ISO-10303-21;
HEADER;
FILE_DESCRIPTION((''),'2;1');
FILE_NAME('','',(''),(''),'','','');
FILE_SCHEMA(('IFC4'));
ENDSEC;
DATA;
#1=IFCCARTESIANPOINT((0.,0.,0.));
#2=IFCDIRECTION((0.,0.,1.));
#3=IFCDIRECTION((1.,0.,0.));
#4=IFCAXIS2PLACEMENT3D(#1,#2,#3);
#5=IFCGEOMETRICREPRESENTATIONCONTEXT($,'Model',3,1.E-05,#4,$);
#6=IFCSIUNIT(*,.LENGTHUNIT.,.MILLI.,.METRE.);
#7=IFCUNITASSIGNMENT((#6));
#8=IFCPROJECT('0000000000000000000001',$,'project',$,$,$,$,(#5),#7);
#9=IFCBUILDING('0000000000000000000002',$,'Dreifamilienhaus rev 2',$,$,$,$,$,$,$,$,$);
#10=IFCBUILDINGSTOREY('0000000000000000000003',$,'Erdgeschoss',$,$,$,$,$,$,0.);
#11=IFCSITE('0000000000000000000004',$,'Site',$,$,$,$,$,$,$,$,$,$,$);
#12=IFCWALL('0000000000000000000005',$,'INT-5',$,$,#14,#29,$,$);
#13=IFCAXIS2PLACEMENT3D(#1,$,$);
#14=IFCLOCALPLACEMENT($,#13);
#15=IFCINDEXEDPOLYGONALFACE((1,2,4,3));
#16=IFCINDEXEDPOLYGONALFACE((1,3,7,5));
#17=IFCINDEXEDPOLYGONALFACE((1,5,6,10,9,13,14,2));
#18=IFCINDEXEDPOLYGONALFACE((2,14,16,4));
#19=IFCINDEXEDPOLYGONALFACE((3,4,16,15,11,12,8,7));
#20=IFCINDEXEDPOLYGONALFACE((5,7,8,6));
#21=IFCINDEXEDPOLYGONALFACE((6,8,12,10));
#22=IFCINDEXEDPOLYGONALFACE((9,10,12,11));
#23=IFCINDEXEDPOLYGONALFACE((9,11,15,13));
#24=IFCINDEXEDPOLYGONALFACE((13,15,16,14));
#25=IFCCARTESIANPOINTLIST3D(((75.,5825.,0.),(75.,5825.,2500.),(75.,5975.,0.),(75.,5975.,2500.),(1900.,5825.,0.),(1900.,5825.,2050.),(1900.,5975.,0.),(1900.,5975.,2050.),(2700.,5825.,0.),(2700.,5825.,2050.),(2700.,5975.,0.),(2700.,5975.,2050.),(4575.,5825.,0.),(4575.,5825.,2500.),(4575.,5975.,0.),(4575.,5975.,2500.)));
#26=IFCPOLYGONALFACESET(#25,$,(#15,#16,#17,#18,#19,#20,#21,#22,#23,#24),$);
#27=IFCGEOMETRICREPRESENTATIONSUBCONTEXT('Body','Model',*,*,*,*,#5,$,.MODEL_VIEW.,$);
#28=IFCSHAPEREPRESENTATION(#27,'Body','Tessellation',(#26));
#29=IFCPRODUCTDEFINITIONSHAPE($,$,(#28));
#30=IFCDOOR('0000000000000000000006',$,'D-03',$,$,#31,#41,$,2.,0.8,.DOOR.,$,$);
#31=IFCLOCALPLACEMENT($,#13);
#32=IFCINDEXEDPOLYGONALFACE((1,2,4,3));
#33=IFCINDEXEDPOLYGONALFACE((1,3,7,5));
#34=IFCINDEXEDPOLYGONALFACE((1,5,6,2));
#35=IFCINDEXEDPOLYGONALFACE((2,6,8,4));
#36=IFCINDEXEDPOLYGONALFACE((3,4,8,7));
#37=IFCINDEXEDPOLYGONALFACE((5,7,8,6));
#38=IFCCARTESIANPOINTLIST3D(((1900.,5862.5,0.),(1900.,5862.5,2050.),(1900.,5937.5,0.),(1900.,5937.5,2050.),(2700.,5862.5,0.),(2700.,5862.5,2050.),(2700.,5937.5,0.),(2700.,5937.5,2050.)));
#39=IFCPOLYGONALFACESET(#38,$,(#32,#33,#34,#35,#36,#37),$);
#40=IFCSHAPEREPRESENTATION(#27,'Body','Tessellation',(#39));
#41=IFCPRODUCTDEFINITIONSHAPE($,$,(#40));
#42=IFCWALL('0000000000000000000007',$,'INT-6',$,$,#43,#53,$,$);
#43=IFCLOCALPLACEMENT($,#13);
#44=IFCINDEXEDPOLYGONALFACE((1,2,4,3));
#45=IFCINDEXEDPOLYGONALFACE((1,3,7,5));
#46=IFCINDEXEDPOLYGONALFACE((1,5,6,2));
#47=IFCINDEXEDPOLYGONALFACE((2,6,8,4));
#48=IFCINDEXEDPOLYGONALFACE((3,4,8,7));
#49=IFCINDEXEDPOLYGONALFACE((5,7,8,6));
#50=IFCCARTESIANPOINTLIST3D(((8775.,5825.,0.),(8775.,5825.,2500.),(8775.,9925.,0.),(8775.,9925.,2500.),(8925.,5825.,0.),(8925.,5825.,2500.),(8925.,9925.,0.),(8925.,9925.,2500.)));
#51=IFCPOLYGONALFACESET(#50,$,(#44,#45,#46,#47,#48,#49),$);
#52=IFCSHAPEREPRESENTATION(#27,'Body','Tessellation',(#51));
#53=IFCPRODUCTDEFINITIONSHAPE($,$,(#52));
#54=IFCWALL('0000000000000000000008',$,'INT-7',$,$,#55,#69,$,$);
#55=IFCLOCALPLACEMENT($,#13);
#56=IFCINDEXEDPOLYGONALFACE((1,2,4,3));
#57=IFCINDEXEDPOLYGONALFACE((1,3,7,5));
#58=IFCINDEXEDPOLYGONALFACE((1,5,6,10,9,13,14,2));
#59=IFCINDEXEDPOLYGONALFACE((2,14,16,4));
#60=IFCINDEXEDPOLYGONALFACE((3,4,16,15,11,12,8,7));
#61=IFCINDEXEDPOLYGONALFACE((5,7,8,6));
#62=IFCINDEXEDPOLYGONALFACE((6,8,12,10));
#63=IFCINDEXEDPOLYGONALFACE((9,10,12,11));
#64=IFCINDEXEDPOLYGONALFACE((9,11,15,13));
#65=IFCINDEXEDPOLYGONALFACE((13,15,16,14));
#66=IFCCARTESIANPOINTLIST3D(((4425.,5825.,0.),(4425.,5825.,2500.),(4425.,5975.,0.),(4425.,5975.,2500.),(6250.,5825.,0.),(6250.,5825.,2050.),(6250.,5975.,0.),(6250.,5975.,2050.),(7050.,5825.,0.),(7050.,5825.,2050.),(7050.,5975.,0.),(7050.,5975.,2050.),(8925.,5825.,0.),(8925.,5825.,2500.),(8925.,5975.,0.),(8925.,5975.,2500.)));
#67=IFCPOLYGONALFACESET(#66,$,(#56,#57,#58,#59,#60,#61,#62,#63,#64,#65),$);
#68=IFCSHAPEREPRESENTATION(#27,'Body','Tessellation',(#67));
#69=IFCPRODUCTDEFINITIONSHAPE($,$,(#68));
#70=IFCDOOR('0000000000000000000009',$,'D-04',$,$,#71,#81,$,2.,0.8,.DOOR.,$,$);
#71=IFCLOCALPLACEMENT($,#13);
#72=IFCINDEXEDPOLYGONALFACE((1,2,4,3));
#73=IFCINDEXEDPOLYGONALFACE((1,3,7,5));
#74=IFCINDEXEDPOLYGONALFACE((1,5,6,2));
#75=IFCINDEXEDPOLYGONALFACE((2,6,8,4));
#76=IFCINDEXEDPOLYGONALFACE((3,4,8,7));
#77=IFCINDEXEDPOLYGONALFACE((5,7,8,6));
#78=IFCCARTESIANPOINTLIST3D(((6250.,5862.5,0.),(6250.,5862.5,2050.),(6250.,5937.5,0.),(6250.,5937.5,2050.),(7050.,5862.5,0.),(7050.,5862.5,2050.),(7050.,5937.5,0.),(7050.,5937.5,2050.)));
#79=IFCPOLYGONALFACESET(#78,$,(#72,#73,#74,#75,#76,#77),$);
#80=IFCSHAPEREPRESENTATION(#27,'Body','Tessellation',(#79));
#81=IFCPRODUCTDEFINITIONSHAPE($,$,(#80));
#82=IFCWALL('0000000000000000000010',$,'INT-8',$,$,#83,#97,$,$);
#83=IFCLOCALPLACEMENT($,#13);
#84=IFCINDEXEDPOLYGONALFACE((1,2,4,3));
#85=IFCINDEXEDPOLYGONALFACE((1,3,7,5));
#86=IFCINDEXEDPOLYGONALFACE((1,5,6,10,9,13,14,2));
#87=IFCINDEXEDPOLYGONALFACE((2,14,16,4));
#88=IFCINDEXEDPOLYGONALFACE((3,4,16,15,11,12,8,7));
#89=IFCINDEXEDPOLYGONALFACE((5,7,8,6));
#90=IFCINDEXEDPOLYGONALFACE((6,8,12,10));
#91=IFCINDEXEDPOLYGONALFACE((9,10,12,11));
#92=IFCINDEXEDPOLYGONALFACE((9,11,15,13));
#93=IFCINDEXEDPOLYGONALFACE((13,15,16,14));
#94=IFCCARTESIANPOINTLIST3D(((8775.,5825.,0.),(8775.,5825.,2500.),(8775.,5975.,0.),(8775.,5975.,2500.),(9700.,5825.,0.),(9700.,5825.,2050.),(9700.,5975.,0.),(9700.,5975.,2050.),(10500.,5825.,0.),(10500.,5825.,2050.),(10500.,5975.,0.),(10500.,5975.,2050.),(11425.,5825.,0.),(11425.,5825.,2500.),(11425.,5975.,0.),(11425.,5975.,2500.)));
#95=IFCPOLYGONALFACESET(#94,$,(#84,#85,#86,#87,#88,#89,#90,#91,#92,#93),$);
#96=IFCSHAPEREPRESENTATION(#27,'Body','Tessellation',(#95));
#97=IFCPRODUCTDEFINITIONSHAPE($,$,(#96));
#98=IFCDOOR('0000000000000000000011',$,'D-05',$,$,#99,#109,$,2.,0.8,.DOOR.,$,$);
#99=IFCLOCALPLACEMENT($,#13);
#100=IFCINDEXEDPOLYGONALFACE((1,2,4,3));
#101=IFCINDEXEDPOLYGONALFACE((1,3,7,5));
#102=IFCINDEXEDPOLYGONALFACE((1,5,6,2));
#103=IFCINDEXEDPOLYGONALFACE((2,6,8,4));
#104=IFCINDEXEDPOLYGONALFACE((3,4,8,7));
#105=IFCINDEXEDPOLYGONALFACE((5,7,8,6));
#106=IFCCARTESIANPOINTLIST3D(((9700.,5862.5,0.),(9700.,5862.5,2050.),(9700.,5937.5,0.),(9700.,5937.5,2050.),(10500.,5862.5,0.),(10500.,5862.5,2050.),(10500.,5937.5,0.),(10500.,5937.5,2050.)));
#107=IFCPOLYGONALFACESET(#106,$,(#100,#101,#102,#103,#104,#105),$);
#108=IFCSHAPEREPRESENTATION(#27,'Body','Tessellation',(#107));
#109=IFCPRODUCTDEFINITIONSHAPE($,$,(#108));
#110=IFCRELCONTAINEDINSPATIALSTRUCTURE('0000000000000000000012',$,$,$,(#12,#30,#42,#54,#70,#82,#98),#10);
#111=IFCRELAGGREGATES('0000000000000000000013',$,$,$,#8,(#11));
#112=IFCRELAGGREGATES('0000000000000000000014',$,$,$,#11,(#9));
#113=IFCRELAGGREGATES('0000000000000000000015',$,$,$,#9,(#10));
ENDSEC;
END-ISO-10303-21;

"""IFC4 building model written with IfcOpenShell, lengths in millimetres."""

from ifc_helpers import new_model, si_unit, origin_with_axes, place, context, subcontext, project, spatial, indexed_curve, outline, extrude, element, fill, save


model = new_model("IFC4")

# Units and contexts
model_context = context("Model", 3, precision=1e-05, world=origin_with_axes())
body_context = subcontext(model_context, "Body", "Model", "MODEL_VIEW")
ifc_project = project(units=[si_unit("LENGTHUNIT", "METRE", prefix="MILLI")], contexts=[model_context])

# Site, building, storey
site = spatial("IfcSite", under=ifc_project, Name="Site")
building = spatial("IfcBuilding", under=site, Name="Dreifamilienhaus rev 2")
storey = spatial("IfcBuildingStorey", under=building, Name="Erdgeschoss", Elevation=0.0)

# Wall, opening, door
wall_1_placement = place(None, origin_with_axes())
wall_1 = element("IfcWall", 1, at=wall_1_placement, inside=storey, Name="INT-5", context=body_context, shape_type="SweptSolid", body=[
    extrude(outline(indexed_curve([(75.0, 5975.0), (4575.0, 5975.0), (4575.0, 5825.0), (75.0, 5825.0), (75.0, 5975.0)])), origin_with_axes(), (0.0, 0.0, 1.0), 2500.0),
])
opening_1_placement = place(wall_1_placement, origin_with_axes())
opening_1 = element("IfcOpeningElement", 2, at=opening_1_placement, cuts=wall_1, context=body_context, shape_type="SweptSolid", body=[
    extrude(outline(indexed_curve([(1900.0, 5995.0), (2700.0, 5995.0), (2700.0, 5805.0), (1900.0, 5805.0), (1900.0, 5995.0)])), origin_with_axes(), (0.0, 0.0, 1.0), 2050.0),
])
door_1_placement = place(opening_1_placement, origin_with_axes())
door_1 = element("IfcDoor", 3, at=door_1_placement, inside=storey, Name="D-03", OverallHeight=2.0, OverallWidth=0.8, PredefinedType="DOOR", context=body_context, shape_type="SweptSolid", body=[
    extrude(outline(indexed_curve([(1900.0, 5937.5), (2700.0, 5937.5), (2700.0, 5862.5), (1900.0, 5862.5), (1900.0, 5937.5)])), origin_with_axes(), (0.0, 0.0, 1.0), 2050.0),
])
fill(opening_1, door_1)

# Wall
wall_2_placement = place(None, origin_with_axes())
element("IfcWall", 4, at=wall_2_placement, inside=storey, Name="INT-6", context=body_context, shape_type="SweptSolid", body=[
    extrude(outline(indexed_curve([(8775.0, 5825.0), (8775.0, 9925.0), (8925.0, 9925.0), (8925.0, 5825.0), (8775.0, 5825.0)])), origin_with_axes(), (0.0, 0.0, 1.0), 2500.0),
])

# Walls, openings, doors
wall_3_placement = place(None, origin_with_axes())
wall_3 = element("IfcWall", 5, at=wall_3_placement, inside=storey, Name="INT-7", context=body_context, shape_type="SweptSolid", body=[
    extrude(outline(indexed_curve([(4425.0, 5975.0), (8925.0, 5975.0), (8925.0, 5825.0), (4425.0, 5825.0), (4425.0, 5975.0)])), origin_with_axes(), (0.0, 0.0, 1.0), 2500.0),
])
opening_2_placement = place(wall_3_placement, origin_with_axes())
opening_2 = element("IfcOpeningElement", 6, at=opening_2_placement, cuts=wall_3, context=body_context, shape_type="SweptSolid", body=[
    extrude(outline(indexed_curve([(6250.0, 5995.0), (7050.0, 5995.0), (7050.0, 5805.0), (6250.0, 5805.0), (6250.0, 5995.0)])), origin_with_axes(), (0.0, 0.0, 1.0), 2050.0),
])
door_2_placement = place(opening_2_placement, origin_with_axes())
door_2 = element("IfcDoor", 7, at=door_2_placement, inside=storey, Name="D-04", OverallHeight=2.0, OverallWidth=0.8, PredefinedType="DOOR", context=body_context, shape_type="SweptSolid", body=[
    extrude(outline(indexed_curve([(6250.0, 5937.5), (7050.0, 5937.5), (7050.0, 5862.5), (6250.0, 5862.5), (6250.0, 5937.5)])), origin_with_axes(), (0.0, 0.0, 1.0), 2050.0),
])
fill(opening_2, door_2)
wall_4_placement = place(None, origin_with_axes())
wall_4 = element("IfcWall", 8, at=wall_4_placement, inside=storey, Name="INT-8", context=body_context, shape_type="SweptSolid", body=[
    extrude(outline(indexed_curve([(8775.0, 5975.0), (11425.0, 5975.0), (11425.0, 5825.0), (8775.0, 5825.0), (8775.0, 5975.0)])), origin_with_axes(), (0.0, 0.0, 1.0), 2500.0),
])
opening_3_placement = place(wall_4_placement, origin_with_axes())
opening_3 = element("IfcOpeningElement", 9, at=opening_3_placement, cuts=wall_4, context=body_context, shape_type="SweptSolid", body=[
    extrude(outline(indexed_curve([(9700.0, 5995.0), (10500.0, 5995.0), (10500.0, 5805.0), (9700.0, 5805.0), (9700.0, 5995.0)])), origin_with_axes(), (0.0, 0.0, 1.0), 2050.0),
])
door_3_placement = place(opening_3_placement, origin_with_axes())
door_3 = element("IfcDoor", 10, at=door_3_placement, inside=storey, Name="D-05", OverallHeight=2.0, OverallWidth=0.8, PredefinedType="DOOR", context=body_context, shape_type="SweptSolid", body=[
    extrude(outline(indexed_curve([(9700.0, 5937.5), (10500.0, 5937.5), (10500.0, 5862.5), (9700.0, 5862.5), (9700.0, 5937.5)])), origin_with_axes(), (0.0, 0.0, 1.0), 2050.0),
])
fill(opening_3, door_3)

save(model, "model.ifc")
